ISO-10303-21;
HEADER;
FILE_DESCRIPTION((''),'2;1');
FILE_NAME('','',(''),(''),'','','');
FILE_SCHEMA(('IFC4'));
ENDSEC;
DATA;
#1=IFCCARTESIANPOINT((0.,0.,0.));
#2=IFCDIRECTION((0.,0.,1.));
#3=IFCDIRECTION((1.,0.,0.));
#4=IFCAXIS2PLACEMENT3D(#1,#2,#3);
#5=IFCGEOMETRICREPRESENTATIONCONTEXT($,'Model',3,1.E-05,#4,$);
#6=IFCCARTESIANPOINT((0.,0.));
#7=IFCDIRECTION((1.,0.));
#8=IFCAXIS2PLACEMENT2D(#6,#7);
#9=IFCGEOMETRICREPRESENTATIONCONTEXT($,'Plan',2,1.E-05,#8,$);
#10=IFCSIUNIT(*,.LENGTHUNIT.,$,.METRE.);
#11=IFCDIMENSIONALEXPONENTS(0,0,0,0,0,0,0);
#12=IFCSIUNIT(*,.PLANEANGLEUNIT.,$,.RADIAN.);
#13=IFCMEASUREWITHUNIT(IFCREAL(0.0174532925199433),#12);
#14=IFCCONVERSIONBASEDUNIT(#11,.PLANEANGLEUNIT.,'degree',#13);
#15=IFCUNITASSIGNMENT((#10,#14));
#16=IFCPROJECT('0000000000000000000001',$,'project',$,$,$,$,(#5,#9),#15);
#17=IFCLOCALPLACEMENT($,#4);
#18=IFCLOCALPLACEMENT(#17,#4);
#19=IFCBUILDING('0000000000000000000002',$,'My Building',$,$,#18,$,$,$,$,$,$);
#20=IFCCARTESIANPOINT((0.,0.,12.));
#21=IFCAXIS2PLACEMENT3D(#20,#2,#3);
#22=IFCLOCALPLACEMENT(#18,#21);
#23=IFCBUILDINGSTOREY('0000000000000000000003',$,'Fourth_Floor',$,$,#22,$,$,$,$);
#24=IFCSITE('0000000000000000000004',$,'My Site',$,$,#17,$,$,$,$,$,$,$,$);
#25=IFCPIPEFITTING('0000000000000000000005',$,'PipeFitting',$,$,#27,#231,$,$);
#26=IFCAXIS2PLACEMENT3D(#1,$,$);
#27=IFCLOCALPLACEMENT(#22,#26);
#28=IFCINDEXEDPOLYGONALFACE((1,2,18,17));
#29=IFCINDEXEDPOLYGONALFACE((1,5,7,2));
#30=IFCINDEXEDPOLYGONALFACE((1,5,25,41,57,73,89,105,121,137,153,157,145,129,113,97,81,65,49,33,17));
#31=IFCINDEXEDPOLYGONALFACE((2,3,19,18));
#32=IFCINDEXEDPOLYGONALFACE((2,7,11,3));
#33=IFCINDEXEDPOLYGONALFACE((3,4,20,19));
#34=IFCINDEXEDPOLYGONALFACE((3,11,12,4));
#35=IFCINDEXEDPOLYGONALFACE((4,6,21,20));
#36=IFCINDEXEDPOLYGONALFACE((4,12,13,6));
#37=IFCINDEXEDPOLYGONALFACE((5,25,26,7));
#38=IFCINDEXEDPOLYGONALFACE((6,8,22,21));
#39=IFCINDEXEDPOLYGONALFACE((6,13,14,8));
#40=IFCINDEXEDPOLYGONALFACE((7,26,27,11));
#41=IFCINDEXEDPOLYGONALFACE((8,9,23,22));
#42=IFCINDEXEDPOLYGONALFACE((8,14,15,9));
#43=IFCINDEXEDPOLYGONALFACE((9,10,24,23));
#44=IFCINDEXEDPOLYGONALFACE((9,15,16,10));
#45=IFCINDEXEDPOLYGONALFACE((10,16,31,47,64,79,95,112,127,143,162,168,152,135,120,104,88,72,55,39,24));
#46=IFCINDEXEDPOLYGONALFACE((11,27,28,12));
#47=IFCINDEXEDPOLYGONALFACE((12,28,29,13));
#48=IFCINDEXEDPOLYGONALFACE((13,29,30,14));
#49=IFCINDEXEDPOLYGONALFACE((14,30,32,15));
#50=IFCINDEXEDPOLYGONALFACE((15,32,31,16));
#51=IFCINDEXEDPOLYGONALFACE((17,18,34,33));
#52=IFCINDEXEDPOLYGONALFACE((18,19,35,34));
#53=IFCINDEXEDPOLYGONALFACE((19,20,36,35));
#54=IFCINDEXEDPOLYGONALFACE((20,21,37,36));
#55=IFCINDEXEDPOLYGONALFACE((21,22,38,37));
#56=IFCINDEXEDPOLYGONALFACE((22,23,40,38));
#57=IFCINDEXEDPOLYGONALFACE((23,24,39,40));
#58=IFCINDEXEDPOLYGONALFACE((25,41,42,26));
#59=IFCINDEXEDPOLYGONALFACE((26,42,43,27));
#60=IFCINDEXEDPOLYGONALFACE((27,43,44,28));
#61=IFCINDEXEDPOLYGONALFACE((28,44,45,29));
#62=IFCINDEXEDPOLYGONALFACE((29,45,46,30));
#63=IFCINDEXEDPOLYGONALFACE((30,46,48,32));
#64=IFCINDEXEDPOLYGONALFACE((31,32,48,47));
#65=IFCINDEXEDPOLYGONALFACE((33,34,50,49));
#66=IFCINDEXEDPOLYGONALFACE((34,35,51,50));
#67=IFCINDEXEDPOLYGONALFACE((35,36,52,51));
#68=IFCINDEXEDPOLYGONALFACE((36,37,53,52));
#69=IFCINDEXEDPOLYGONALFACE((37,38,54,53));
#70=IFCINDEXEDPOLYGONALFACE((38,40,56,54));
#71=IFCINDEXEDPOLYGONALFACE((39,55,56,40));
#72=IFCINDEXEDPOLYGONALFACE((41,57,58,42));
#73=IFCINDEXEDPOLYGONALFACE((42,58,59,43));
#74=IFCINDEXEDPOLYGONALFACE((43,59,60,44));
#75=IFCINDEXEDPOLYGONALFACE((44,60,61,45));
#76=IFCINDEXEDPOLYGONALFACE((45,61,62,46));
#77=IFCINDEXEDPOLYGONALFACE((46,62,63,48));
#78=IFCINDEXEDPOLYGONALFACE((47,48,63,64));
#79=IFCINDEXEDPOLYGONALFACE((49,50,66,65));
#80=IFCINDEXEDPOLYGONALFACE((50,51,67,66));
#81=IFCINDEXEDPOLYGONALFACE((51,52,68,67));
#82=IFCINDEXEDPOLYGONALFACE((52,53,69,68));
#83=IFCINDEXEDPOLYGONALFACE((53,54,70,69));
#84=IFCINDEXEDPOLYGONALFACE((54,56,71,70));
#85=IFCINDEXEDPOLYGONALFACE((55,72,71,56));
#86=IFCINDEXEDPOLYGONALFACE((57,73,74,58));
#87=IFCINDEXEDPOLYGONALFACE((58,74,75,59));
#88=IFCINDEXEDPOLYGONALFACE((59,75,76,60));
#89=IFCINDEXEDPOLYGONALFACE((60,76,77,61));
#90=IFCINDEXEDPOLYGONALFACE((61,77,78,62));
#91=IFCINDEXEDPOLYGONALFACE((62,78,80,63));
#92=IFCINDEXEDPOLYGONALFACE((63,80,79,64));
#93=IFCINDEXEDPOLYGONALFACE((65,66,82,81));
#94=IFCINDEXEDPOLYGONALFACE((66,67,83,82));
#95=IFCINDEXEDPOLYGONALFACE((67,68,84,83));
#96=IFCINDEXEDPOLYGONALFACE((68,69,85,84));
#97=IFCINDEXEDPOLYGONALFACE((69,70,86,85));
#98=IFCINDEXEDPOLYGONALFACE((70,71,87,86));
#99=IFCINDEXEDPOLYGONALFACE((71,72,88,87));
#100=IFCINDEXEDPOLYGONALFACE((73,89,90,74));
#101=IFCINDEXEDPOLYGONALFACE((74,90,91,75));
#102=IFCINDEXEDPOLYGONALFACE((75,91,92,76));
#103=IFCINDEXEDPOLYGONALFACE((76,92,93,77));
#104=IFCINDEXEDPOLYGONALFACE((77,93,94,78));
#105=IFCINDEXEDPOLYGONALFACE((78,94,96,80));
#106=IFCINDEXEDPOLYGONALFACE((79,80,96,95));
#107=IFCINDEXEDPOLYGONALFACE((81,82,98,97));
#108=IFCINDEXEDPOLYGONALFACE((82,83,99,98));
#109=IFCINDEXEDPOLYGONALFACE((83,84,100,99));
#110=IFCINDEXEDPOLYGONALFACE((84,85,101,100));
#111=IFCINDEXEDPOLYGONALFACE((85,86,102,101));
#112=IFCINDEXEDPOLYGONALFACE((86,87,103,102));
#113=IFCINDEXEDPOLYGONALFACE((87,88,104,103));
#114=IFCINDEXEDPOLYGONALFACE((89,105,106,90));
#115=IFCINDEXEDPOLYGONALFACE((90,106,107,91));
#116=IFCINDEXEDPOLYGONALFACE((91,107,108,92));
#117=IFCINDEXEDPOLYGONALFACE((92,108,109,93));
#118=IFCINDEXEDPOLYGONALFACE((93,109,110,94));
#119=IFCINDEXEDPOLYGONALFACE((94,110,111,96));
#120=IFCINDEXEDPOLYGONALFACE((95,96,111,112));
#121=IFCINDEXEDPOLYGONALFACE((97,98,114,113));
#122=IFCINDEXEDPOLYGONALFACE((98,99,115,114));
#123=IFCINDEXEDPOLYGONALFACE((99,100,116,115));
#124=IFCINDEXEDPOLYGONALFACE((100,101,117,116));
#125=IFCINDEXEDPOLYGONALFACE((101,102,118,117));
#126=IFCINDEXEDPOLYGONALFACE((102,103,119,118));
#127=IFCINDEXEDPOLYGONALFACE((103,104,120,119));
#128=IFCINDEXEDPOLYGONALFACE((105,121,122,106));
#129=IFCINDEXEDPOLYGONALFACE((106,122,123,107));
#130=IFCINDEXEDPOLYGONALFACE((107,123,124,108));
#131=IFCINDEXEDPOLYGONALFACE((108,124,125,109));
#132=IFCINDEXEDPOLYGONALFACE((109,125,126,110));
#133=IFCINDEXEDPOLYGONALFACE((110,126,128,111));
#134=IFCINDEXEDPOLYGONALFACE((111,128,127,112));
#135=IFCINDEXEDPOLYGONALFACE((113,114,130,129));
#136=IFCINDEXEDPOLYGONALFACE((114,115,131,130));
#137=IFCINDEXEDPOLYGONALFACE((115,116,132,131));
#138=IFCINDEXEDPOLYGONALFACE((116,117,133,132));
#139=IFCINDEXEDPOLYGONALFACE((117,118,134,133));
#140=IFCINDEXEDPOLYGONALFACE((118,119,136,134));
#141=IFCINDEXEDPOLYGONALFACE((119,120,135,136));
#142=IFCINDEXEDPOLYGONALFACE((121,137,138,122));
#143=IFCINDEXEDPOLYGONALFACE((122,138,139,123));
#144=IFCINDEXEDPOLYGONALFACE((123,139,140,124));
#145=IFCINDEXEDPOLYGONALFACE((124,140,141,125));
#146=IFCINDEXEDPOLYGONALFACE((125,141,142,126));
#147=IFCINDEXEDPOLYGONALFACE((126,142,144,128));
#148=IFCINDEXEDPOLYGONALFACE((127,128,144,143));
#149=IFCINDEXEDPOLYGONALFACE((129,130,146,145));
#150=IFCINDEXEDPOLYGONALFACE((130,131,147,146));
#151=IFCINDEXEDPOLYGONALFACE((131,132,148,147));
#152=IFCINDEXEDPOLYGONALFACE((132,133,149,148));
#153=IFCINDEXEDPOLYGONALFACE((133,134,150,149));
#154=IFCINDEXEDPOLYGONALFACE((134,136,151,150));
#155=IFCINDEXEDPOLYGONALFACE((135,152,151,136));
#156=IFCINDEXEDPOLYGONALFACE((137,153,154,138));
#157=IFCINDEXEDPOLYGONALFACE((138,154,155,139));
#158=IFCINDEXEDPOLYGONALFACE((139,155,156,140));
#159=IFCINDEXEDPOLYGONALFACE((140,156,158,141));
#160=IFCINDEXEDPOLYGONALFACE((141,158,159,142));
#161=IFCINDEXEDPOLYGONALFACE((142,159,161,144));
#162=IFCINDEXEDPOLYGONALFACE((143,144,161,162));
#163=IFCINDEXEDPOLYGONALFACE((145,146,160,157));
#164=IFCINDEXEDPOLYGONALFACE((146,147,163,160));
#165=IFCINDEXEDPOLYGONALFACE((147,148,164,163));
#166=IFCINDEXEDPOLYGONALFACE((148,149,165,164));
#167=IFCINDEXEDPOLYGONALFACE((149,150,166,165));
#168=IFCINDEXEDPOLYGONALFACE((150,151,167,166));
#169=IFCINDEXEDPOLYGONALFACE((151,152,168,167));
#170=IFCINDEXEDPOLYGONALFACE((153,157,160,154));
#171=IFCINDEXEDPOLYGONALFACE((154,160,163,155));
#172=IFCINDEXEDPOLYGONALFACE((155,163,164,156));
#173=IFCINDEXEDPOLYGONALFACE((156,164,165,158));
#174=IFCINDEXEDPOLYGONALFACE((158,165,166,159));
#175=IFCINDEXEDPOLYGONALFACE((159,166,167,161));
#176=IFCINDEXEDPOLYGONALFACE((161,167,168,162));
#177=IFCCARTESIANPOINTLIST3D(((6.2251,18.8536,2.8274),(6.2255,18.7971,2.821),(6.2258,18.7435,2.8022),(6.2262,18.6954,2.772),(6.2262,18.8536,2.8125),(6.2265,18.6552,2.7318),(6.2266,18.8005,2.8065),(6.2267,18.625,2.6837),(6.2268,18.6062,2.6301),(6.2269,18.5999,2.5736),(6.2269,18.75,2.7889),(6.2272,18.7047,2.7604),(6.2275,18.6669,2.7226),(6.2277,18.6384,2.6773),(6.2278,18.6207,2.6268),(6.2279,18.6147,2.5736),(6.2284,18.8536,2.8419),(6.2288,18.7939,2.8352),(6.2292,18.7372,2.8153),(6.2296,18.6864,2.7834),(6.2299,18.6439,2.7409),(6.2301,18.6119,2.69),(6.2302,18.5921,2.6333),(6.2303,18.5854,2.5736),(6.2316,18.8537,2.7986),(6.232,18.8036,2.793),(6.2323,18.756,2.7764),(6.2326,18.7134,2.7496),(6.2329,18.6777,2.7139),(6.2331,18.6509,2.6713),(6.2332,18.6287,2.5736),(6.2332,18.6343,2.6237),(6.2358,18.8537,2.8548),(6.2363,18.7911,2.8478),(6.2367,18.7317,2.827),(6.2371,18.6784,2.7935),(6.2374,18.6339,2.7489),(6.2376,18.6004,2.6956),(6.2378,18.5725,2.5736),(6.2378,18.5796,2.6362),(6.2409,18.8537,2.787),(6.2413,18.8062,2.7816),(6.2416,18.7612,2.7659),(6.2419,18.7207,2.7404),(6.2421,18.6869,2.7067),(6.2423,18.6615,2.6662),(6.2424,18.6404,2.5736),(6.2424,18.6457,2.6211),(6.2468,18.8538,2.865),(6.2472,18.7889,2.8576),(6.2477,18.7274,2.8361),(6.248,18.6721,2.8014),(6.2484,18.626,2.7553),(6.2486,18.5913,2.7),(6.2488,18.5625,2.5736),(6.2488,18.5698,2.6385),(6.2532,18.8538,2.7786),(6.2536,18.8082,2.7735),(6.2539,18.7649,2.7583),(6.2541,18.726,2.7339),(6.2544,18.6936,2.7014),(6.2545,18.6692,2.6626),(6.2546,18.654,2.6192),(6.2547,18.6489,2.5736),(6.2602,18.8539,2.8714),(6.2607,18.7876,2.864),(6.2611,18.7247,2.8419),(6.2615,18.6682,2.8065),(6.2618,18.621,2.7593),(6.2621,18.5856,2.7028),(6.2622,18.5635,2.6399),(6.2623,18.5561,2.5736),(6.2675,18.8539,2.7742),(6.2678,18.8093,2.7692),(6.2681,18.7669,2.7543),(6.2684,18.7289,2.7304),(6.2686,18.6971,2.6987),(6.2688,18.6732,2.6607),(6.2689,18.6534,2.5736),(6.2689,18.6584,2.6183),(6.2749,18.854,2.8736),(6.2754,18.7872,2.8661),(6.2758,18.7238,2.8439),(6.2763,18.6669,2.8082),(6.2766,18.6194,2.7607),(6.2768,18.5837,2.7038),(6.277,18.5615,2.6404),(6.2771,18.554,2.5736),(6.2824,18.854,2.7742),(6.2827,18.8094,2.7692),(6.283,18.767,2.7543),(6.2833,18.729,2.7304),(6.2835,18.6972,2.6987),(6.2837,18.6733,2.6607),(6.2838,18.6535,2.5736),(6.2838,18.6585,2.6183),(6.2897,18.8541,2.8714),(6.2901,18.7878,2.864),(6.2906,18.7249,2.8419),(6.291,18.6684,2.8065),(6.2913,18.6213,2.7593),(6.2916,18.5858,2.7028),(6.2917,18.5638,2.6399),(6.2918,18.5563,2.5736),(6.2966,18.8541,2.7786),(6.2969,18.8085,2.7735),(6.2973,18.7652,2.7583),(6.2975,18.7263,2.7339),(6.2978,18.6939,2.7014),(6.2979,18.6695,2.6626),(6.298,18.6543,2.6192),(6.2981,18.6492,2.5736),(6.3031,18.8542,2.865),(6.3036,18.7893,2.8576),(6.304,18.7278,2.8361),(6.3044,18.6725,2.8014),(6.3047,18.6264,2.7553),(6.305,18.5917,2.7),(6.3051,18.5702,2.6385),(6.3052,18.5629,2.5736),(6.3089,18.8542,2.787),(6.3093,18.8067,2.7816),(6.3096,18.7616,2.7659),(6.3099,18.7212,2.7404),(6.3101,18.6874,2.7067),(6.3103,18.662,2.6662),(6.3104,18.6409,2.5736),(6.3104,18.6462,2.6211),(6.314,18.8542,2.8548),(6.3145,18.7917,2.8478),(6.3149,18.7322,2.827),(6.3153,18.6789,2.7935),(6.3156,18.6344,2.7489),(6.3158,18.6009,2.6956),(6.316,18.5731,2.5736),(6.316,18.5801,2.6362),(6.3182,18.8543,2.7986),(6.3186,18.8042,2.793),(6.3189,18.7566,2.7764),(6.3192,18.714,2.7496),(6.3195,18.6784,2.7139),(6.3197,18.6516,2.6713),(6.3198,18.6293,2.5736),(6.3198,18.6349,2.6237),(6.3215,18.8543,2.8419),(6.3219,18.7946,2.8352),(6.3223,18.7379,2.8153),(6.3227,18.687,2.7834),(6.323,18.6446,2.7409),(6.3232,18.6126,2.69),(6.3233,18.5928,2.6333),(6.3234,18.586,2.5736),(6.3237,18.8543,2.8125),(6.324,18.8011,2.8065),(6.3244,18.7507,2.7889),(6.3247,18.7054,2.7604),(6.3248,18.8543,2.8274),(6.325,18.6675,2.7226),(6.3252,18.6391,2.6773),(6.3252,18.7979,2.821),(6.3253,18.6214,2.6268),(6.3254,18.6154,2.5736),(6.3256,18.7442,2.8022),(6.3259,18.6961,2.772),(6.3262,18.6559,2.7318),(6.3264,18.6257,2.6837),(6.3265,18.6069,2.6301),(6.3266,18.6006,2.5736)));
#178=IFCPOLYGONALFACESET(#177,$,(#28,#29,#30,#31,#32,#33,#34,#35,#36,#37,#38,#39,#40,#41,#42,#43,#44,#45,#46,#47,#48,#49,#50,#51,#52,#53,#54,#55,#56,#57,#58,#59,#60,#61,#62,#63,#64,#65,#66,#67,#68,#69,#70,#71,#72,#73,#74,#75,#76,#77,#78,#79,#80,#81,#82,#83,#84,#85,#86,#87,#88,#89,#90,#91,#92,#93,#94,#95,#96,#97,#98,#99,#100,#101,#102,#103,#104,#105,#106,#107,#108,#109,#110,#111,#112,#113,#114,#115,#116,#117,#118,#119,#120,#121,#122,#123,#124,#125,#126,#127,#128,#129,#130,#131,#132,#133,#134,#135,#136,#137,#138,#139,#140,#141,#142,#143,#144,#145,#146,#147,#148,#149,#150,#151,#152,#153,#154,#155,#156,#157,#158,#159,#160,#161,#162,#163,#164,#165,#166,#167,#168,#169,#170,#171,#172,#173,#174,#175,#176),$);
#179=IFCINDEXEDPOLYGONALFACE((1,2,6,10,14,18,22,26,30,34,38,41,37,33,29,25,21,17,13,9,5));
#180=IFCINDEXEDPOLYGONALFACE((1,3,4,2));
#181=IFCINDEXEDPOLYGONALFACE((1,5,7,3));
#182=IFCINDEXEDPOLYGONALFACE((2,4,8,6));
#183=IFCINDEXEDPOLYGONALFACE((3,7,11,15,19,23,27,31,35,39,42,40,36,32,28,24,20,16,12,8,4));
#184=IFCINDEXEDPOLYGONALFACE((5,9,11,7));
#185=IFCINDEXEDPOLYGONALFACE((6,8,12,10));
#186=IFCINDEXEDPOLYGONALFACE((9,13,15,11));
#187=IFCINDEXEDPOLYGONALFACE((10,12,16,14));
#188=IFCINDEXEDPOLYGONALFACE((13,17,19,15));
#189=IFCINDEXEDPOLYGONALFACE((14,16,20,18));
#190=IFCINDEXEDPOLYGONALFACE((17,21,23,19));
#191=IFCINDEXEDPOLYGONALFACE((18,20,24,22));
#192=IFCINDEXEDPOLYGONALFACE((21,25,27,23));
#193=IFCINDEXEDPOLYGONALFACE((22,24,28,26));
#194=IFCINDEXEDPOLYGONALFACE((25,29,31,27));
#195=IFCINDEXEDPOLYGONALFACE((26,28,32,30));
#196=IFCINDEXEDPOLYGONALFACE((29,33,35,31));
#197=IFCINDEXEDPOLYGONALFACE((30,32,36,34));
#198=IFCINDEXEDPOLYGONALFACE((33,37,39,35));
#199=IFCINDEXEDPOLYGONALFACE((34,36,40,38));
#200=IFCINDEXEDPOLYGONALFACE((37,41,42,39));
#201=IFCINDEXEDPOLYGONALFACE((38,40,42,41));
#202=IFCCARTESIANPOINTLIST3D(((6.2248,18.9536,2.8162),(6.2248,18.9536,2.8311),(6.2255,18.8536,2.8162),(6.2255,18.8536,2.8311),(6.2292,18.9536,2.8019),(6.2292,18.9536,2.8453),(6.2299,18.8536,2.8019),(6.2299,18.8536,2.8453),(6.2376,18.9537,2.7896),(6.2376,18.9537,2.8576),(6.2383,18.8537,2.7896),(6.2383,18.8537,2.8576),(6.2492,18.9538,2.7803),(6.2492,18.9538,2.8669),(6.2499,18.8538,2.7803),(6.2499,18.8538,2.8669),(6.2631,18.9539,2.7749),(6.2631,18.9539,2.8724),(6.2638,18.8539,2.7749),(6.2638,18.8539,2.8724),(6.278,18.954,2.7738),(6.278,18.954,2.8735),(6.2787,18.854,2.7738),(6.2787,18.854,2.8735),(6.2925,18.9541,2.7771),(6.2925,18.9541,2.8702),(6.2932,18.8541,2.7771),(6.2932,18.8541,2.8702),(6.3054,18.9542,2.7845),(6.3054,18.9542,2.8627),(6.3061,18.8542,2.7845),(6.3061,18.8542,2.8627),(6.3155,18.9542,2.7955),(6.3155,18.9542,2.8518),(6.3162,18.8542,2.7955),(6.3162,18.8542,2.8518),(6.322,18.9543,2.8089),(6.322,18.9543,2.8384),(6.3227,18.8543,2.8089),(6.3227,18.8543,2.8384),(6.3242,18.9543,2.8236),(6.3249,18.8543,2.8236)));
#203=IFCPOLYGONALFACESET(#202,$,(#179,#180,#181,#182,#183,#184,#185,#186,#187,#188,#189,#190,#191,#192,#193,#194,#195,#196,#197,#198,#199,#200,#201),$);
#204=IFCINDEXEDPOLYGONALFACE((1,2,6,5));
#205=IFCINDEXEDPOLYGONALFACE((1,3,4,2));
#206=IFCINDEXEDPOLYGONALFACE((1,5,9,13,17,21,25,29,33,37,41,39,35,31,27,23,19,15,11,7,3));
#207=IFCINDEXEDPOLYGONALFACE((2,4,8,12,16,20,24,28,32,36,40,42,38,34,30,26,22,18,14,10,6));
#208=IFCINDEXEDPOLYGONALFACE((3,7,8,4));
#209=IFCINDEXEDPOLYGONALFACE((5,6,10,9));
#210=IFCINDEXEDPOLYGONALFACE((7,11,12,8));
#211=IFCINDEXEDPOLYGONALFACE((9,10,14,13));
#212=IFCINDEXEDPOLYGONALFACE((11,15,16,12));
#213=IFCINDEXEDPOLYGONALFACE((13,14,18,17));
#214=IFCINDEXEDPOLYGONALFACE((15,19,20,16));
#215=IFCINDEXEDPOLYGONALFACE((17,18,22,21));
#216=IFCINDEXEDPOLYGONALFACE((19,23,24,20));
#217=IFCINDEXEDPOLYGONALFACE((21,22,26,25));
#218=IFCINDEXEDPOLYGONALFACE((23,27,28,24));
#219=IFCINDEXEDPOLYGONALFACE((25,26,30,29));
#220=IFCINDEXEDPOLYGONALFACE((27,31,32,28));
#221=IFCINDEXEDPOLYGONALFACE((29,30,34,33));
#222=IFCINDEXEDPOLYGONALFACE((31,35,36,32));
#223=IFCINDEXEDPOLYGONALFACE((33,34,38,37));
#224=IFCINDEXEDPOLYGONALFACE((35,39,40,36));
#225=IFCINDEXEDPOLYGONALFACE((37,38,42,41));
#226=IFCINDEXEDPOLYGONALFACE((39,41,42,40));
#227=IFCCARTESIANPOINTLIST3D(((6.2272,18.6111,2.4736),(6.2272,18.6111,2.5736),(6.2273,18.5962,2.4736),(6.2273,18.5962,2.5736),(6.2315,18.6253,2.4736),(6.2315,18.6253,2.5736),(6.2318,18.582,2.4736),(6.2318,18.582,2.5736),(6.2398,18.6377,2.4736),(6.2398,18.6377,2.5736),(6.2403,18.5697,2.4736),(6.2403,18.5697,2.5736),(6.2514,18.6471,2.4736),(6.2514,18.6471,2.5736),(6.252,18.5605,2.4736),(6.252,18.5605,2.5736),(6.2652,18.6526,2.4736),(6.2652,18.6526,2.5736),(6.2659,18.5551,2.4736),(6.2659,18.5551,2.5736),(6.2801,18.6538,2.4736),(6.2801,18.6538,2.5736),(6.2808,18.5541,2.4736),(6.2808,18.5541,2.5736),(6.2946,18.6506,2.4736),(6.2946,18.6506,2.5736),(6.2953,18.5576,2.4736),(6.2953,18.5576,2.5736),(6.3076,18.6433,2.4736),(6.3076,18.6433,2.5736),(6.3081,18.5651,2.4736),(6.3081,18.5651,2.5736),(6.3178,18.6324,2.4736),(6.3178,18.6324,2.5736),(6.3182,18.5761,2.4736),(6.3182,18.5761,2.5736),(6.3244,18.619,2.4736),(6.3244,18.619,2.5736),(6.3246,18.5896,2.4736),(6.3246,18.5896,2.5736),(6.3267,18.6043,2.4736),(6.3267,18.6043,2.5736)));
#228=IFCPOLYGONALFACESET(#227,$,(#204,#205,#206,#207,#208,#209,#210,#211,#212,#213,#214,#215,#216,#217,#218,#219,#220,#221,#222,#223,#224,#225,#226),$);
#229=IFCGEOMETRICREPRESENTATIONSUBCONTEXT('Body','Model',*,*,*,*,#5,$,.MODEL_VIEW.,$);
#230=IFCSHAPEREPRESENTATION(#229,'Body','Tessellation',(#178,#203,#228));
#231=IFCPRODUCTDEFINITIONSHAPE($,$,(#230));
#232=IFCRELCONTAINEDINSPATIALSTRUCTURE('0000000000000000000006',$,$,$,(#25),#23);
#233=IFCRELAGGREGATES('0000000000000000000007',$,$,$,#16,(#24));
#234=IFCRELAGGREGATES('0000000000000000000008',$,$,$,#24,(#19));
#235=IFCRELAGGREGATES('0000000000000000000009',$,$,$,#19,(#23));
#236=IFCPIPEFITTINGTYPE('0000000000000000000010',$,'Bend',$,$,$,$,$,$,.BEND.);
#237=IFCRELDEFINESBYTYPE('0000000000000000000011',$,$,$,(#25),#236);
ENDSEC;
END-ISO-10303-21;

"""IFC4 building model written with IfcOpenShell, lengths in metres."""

from ifc_helpers import new_model, entity, si_unit, converted_unit, frame, origin_with_axes, origin_2d_with_axis, place, context, subcontext, project, spatial, circle, extrude, source, transform, mapped, type_object, type_shapes, element, save


model = new_model("IFC4")

# Units and contexts
model_context = context("Model", 3, precision=1e-05, world=origin_with_axes())
plan_context = context("Plan", 2, precision=1e-05, world=origin_2d_with_axis())
body_context_1 = subcontext(model_context, "Body", "Model", "MODEL_VIEW")
ifc_project = project(units=[si_unit("LENGTHUNIT", "METRE"), converted_unit("PLANEANGLEUNIT", "degree", entity("IfcReal", 0.0174532925199433), si_unit("PLANEANGLEUNIT", "RADIAN"), dimensions=[0, 0, 0, 0, 0, 0, 0])], contexts=[model_context, plan_context])

# Site, building, storey
site_placement = place(None, origin_with_axes())
site = spatial("IfcSite", under=ifc_project, at=site_placement, Name="My Site")
building_placement = place(site_placement, origin_with_axes())
building = spatial("IfcBuilding", under=site, at=building_placement, Name="My Building")
storey_placement = place(building_placement, frame((0.0, 0.0, 12.0), z_axis=(0.0, 0.0, 1.0), x_axis=(1.0, 0.0, 0.0)))
storey = spatial("IfcBuildingStorey", under=building, at=storey_placement, Name="Fourth_Floor")

# Pipe fitting
pipe_fitting_type = type_object("IfcPipeFittingType", Name="Bend", PredefinedType="BEND")
shared_shape_1 = source(origin_with_axes(), body_context_1, "Body", "SolidModel", [
    entity("IfcSweptDiskSolid", entity("IfcIndexedPolyCurve", entity("IfcCartesianPointList3D", [[0.0, 0.0, -0.1], [0.0, 0.0732, -0.2768], [0.0, 0.25, -0.35]]), [entity("IfcArcIndex", [1, 2, 3])]), 0.05),
    extrude(circle(Radius=0.05), origin_with_axes(), (0.0, 0.0, -1.0), 0.1),
    extrude(circle(Radius=0.05), frame((0.0, 0.25, -0.35), z_axis=(0.0, 1.0, 0.0), x_axis=(1.0, 0.0, 0.0)), (0.0, 0.0, 1.0), 0.1),
])
type_shapes(pipe_fitting_type, [shared_shape_1])
pipe_fitting_placement = place(storey_placement, frame((6.2742, 18.954, 2.8236), z_axis=(-0.007084, 0.999975, 0.0), x_axis=(0.999975, 0.007084, 0.0)))
element("IfcPipeFitting", 1, at=pipe_fitting_placement, inside=storey, type_object=pipe_fitting_type, Name="PipeFitting", context=body_context_1, shape_type="MappedRepresentation", body=[
    mapped(shared_shape_1, transform((0.0, 0.0, 0.0), x_axis=(1.0, 0.0, 0.0), y_axis=(0.0, 1.0, 0.0), z_axis=(0.0, 0.0, 1.0), scale=1.0)),
])

save(model, "model.ifc")
